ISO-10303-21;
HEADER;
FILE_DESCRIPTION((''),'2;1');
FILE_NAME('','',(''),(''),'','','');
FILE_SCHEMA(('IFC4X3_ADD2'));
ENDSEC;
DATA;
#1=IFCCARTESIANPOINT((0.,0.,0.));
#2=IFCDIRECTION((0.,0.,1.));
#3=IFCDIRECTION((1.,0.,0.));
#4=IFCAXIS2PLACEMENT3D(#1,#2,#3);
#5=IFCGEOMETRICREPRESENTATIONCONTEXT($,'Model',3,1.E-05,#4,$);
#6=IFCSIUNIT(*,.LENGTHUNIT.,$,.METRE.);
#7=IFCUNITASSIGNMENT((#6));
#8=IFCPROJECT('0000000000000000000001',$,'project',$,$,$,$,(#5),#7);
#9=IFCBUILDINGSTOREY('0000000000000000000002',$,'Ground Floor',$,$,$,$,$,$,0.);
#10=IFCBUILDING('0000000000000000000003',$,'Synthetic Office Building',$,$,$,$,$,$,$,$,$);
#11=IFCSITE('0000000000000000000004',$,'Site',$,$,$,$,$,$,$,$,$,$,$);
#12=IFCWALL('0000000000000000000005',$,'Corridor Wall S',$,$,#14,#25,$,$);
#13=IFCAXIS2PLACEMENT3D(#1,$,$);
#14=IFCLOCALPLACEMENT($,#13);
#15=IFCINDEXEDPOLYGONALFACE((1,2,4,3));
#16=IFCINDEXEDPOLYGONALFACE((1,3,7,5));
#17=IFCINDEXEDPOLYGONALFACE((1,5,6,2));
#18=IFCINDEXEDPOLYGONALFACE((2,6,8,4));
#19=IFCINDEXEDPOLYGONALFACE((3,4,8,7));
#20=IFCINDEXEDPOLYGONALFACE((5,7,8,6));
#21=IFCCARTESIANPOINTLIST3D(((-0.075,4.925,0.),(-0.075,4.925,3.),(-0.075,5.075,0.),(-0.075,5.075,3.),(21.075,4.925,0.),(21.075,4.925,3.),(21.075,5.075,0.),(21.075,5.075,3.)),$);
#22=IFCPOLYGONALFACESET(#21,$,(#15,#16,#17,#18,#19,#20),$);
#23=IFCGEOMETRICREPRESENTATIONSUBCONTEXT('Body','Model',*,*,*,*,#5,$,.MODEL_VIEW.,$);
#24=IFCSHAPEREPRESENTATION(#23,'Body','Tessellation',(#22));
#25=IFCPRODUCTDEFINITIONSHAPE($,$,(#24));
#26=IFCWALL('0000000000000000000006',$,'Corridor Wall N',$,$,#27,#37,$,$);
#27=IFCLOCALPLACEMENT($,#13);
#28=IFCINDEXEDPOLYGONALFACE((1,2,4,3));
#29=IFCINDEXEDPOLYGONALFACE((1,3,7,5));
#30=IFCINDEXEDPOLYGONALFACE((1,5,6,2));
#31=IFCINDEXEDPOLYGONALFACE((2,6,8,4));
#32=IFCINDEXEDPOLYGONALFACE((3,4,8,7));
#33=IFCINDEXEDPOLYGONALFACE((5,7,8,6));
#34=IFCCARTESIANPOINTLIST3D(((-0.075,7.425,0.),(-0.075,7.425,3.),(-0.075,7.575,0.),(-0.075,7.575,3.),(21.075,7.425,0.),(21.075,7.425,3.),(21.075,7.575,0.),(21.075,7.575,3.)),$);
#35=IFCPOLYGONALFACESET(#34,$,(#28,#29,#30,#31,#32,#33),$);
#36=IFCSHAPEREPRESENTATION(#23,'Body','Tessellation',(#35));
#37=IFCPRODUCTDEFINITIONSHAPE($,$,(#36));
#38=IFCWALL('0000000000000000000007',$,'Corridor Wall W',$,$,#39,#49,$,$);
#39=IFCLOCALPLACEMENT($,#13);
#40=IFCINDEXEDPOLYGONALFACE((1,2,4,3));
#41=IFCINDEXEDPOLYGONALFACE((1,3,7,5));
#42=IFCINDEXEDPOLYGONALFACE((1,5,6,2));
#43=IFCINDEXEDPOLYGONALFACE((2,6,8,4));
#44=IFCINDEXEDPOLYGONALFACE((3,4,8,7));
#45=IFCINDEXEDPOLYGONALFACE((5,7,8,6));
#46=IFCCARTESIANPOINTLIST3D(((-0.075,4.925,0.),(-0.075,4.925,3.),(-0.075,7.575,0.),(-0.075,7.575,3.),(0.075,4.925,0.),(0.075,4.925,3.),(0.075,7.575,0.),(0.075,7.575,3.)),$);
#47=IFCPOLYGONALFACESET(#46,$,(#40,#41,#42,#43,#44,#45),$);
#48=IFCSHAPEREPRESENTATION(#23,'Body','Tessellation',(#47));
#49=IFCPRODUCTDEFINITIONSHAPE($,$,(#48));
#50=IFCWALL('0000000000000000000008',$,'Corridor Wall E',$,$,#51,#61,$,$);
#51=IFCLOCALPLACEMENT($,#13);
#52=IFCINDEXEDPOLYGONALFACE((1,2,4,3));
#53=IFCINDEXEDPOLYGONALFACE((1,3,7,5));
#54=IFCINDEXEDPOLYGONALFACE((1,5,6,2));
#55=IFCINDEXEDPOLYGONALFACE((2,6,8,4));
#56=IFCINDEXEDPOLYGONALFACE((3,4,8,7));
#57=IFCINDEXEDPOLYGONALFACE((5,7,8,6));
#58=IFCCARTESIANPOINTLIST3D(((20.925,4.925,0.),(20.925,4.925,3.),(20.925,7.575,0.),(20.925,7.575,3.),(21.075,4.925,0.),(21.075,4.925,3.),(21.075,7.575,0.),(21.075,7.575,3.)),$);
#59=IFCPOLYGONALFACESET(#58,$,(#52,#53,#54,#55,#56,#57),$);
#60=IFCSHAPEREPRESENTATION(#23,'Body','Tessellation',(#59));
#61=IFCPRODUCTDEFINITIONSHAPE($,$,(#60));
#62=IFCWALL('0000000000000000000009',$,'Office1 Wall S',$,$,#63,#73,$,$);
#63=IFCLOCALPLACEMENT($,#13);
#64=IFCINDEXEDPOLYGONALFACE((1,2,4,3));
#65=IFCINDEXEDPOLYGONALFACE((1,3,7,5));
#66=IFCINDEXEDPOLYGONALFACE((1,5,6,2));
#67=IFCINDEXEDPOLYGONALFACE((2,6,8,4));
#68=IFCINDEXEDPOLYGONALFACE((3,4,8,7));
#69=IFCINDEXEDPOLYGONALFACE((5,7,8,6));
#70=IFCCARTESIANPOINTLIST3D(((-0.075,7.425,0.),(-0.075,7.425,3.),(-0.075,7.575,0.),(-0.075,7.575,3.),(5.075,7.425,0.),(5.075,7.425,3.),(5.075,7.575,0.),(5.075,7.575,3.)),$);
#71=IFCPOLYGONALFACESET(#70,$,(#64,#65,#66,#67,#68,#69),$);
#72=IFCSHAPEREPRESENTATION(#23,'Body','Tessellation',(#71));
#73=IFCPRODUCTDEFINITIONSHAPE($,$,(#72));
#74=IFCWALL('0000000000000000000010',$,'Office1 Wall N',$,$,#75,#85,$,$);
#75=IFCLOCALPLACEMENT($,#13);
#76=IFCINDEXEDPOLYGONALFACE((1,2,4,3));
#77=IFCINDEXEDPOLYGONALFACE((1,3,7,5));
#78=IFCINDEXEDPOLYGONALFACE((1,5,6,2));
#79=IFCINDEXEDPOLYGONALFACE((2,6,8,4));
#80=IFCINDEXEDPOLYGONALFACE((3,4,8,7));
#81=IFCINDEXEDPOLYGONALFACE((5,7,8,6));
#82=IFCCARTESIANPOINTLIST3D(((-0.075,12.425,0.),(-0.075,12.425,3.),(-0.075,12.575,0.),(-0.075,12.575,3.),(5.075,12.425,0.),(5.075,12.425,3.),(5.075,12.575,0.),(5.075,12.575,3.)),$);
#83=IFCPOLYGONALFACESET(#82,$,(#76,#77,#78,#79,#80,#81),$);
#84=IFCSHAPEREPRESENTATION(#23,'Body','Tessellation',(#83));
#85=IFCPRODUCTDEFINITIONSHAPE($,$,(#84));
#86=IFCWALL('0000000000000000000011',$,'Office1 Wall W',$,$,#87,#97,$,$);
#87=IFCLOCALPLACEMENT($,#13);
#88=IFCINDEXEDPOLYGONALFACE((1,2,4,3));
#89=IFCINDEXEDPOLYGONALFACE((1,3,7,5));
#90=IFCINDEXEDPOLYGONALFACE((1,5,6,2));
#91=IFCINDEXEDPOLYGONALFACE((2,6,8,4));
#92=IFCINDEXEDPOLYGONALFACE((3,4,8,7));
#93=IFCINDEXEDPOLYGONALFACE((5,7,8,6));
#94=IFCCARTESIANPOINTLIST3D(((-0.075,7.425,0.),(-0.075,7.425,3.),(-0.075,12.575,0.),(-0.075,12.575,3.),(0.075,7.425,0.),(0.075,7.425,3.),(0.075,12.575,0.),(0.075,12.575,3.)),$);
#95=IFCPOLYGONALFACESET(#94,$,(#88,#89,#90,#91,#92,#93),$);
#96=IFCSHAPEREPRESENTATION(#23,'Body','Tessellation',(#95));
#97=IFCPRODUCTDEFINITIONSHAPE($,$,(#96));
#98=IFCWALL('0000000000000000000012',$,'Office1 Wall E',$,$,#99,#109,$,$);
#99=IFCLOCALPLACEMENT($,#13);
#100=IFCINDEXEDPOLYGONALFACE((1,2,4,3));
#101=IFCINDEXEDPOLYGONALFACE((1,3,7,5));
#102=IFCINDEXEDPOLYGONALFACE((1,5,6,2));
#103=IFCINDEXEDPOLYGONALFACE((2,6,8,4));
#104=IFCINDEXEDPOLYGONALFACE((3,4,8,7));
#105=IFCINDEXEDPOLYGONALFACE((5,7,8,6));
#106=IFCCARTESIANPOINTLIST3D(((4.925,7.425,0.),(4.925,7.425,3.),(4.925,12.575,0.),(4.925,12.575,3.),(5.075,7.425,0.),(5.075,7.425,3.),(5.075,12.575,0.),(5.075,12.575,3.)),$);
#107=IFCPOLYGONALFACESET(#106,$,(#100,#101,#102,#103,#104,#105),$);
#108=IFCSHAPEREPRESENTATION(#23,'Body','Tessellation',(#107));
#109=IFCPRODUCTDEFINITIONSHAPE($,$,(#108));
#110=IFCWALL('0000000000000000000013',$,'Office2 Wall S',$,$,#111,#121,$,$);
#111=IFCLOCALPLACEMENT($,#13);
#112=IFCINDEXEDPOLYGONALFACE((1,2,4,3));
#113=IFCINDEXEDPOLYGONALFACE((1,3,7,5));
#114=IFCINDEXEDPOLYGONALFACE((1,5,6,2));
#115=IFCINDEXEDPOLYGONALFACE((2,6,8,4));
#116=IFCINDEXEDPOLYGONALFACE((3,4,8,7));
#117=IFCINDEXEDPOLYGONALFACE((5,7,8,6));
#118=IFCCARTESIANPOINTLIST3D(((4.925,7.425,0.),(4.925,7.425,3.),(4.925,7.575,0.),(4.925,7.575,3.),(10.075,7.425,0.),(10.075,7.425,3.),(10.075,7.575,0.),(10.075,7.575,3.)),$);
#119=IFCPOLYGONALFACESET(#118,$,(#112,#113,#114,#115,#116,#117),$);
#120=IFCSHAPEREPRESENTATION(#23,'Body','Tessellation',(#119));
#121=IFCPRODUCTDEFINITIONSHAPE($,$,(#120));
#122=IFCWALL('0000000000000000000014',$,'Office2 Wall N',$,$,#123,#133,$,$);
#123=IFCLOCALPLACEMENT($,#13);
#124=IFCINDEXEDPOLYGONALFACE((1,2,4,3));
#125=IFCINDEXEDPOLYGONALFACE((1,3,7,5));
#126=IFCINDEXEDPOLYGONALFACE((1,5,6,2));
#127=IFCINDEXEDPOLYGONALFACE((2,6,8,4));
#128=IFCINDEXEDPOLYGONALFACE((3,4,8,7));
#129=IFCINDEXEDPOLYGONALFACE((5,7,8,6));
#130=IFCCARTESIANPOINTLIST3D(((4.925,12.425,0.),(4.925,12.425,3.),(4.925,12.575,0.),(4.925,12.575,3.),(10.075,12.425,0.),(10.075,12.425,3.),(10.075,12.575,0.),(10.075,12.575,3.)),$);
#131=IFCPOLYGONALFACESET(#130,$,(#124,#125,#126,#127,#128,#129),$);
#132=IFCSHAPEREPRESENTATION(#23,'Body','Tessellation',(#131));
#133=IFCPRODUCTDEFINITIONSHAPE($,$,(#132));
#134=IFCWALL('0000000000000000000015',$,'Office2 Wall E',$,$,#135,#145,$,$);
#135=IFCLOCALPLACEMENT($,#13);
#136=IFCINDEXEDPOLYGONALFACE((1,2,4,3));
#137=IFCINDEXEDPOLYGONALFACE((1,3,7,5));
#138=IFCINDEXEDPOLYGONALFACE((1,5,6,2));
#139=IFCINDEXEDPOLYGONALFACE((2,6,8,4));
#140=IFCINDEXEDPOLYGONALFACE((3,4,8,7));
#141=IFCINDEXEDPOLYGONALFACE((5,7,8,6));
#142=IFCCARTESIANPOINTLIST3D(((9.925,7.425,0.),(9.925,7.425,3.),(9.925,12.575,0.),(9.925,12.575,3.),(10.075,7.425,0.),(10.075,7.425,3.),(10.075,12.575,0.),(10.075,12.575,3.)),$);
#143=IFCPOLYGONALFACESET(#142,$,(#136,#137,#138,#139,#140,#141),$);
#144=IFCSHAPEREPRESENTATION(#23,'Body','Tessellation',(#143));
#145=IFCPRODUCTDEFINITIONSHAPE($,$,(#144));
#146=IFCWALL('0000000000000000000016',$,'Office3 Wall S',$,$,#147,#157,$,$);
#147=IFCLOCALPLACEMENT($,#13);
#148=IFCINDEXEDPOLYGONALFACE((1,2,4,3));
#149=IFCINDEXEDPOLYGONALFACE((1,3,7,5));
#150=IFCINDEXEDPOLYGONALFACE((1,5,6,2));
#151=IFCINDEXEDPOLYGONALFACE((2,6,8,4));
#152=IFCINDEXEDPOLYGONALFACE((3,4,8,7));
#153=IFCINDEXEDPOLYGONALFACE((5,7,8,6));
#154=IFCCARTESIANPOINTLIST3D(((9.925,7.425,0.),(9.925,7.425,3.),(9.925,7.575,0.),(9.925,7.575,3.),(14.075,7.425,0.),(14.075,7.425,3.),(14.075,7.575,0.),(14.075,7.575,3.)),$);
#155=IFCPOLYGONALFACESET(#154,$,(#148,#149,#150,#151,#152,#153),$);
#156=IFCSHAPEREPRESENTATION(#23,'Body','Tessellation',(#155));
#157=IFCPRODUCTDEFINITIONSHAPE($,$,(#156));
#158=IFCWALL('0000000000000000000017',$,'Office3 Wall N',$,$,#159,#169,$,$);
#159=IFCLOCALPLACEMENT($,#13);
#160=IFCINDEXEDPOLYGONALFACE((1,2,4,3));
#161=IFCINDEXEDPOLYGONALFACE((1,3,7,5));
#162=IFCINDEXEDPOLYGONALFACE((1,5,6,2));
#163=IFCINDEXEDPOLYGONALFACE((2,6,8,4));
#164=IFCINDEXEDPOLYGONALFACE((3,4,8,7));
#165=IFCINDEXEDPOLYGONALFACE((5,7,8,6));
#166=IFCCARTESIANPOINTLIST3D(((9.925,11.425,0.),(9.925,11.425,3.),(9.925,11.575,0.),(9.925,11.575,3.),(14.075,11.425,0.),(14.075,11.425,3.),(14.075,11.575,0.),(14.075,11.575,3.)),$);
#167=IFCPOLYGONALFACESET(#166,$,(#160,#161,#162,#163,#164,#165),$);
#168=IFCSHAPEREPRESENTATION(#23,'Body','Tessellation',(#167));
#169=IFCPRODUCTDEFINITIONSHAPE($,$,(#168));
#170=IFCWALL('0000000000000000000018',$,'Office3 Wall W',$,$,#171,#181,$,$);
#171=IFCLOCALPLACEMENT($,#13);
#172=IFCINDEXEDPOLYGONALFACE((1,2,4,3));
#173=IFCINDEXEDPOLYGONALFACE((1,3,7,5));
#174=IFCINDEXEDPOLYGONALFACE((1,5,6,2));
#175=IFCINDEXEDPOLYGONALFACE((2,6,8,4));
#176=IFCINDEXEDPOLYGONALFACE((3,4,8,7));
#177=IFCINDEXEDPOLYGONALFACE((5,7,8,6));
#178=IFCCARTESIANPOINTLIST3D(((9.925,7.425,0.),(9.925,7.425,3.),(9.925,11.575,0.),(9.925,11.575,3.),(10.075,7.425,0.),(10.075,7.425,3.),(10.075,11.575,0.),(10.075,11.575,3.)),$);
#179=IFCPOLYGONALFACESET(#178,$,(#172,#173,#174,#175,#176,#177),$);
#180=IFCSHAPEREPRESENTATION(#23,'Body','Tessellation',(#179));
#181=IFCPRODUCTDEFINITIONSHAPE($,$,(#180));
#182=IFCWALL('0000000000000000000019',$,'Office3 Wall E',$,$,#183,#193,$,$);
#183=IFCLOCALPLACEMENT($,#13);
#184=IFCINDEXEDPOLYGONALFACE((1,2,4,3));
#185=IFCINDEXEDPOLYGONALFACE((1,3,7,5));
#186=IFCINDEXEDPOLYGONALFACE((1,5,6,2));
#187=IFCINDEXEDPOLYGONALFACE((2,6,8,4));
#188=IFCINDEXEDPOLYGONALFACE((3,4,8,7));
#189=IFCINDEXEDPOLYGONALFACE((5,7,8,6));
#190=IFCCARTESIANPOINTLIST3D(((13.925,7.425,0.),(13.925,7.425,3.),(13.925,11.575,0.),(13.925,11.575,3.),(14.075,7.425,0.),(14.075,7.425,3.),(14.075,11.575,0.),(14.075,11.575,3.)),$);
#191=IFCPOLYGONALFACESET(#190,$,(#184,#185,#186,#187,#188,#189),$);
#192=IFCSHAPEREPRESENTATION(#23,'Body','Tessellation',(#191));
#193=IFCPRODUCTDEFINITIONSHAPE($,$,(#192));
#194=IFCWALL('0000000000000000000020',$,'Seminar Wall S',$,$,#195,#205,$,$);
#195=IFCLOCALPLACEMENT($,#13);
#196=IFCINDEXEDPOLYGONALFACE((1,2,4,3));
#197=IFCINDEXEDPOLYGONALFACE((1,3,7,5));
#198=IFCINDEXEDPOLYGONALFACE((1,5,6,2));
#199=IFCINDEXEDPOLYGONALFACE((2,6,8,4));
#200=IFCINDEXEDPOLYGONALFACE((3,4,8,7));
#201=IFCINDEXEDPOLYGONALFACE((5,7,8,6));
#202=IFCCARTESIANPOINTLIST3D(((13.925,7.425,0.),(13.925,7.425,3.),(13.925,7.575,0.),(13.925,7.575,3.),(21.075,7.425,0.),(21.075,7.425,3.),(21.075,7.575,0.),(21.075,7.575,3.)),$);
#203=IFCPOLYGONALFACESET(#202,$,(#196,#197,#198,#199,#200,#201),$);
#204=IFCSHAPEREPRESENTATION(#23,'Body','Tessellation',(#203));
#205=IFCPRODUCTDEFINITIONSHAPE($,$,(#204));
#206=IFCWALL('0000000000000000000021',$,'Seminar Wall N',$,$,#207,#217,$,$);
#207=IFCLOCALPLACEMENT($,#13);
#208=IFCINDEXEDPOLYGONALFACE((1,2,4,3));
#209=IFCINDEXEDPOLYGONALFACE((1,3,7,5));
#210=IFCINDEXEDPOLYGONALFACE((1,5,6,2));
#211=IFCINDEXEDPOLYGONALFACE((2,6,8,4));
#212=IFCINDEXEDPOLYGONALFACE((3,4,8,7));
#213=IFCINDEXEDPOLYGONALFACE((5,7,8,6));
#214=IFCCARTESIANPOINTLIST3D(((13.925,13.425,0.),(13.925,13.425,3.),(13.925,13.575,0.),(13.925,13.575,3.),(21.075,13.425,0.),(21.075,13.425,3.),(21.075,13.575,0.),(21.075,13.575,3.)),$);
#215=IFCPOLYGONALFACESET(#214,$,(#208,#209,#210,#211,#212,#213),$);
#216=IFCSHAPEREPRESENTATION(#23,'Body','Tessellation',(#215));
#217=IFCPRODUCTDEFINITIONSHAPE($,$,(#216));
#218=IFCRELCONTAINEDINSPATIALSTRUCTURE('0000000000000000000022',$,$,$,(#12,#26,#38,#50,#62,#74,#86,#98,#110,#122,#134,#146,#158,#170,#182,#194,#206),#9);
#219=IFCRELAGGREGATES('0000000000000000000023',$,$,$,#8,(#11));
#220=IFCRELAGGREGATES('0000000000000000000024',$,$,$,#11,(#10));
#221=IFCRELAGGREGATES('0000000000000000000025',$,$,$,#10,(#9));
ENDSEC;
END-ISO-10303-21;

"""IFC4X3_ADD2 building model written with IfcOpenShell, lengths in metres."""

from ifc_helpers import new_model, si_unit, origin_with_axes, place, context, subcontext, project, spatial, polyline, outline, extrude, element, save


model = new_model("IFC4X3_ADD2")

# Units and contexts
model_context = context("Model", 3, precision=1e-05, world=origin_with_axes())
body_context = subcontext(model_context, "Body", "Model", "MODEL_VIEW")
ifc_project = project(units=[si_unit("LENGTHUNIT", "METRE")], contexts=[model_context])

# Site, building, storey
site = spatial("IfcSite", under=ifc_project, Name="Site")
building = spatial("IfcBuilding", under=site, Name="Synthetic Office Building")
storey = spatial("IfcBuildingStorey", under=building, Name="Ground Floor", Elevation=0.0)

# Walls
wall_1_placement = place(None, origin_with_axes())
element("IfcWall", 1, at=wall_1_placement, inside=storey, Name="Corridor Wall S", context=body_context, shape_type="SweptSolid", body=[
    extrude(outline(polyline([(-0.075, 4.925), (21.075, 4.925), (21.075, 5.075), (-0.075, 5.075), (-0.075, 4.925)])), origin_with_axes(), (0.0, 0.0, 1.0), 3.0),
])
wall_2_placement = place(None, origin_with_axes())
element("IfcWall", 2, at=wall_2_placement, inside=storey, Name="Corridor Wall N", context=body_context, shape_type="SweptSolid", body=[
    extrude(outline(polyline([(-0.075, 7.425), (21.075, 7.425), (21.075, 7.575), (-0.075, 7.575), (-0.075, 7.425)])), origin_with_axes(), (0.0, 0.0, 1.0), 3.0),
])
wall_3_placement = place(None, origin_with_axes())
element("IfcWall", 3, at=wall_3_placement, inside=storey, Name="Corridor Wall W", context=body_context, shape_type="SweptSolid", body=[
    extrude(outline(polyline([(-0.075, 4.925), (0.075, 4.925), (0.075, 7.575), (-0.075, 7.575), (-0.075, 4.925)])), origin_with_axes(), (0.0, 0.0, 1.0), 3.0),
])
wall_4_placement = place(None, origin_with_axes())
element("IfcWall", 4, at=wall_4_placement, inside=storey, Name="Corridor Wall E", context=body_context, shape_type="SweptSolid", body=[
    extrude(outline(polyline([(20.925, 4.925), (21.075, 4.925), (21.075, 7.575), (20.925, 7.575), (20.925, 4.925)])), origin_with_axes(), (0.0, 0.0, 1.0), 3.0),
])
wall_5_placement = place(None, origin_with_axes())
element("IfcWall", 5, at=wall_5_placement, inside=storey, Name="Office1 Wall S", context=body_context, shape_type="SweptSolid", body=[
    extrude(outline(polyline([(-0.075, 7.425), (5.075, 7.425), (5.075, 7.575), (-0.075, 7.575), (-0.075, 7.425)])), origin_with_axes(), (0.0, 0.0, 1.0), 3.0),
])
wall_6_placement = place(None, origin_with_axes())
element("IfcWall", 6, at=wall_6_placement, inside=storey, Name="Office1 Wall N", context=body_context, shape_type="SweptSolid", body=[
    extrude(outline(polyline([(-0.075, 12.425), (5.075, 12.425), (5.075, 12.575), (-0.075, 12.575), (-0.075, 12.425)])), origin_with_axes(), (0.0, 0.0, 1.0), 3.0),
])
wall_7_placement = place(None, origin_with_axes())
element("IfcWall", 7, at=wall_7_placement, inside=storey, Name="Office1 Wall W", context=body_context, shape_type="SweptSolid", body=[
    extrude(outline(polyline([(-0.075, 7.425), (0.075, 7.425), (0.075, 12.575), (-0.075, 12.575), (-0.075, 7.425)])), origin_with_axes(), (0.0, 0.0, 1.0), 3.0),
])
wall_8_placement = place(None, origin_with_axes())
element("IfcWall", 8, at=wall_8_placement, inside=storey, Name="Office1 Wall E", context=body_context, shape_type="SweptSolid", body=[
    extrude(outline(polyline([(4.925, 7.425), (5.075, 7.425), (5.075, 12.575), (4.925, 12.575), (4.925, 7.425)])), origin_with_axes(), (0.0, 0.0, 1.0), 3.0),
])
wall_9_placement = place(None, origin_with_axes())
element("IfcWall", 9, at=wall_9_placement, inside=storey, Name="Office2 Wall S", context=body_context, shape_type="SweptSolid", body=[
    extrude(outline(polyline([(4.925, 7.425), (10.075, 7.425), (10.075, 7.575), (4.925, 7.575), (4.925, 7.425)])), origin_with_axes(), (0.0, 0.0, 1.0), 3.0),
])
wall_10_placement = place(None, origin_with_axes())
element("IfcWall", 10, at=wall_10_placement, inside=storey, Name="Office2 Wall N", context=body_context, shape_type="SweptSolid", body=[
    extrude(outline(polyline([(4.925, 12.425), (10.075, 12.425), (10.075, 12.575), (4.925, 12.575), (4.925, 12.425)])), origin_with_axes(), (0.0, 0.0, 1.0), 3.0),
])
wall_11_placement = place(None, origin_with_axes())
element("IfcWall", 11, at=wall_11_placement, inside=storey, Name="Office2 Wall E", context=body_context, shape_type="SweptSolid", body=[
    extrude(outline(polyline([(9.925, 7.425), (10.075, 7.425), (10.075, 12.575), (9.925, 12.575), (9.925, 7.425)])), origin_with_axes(), (0.0, 0.0, 1.0), 3.0),
])
wall_12_placement = place(None, origin_with_axes())
element("IfcWall", 12, at=wall_12_placement, inside=storey, Name="Office3 Wall S", context=body_context, shape_type="SweptSolid", body=[
    extrude(outline(polyline([(9.925, 7.425), (14.075, 7.425), (14.075, 7.575), (9.925, 7.575), (9.925, 7.425)])), origin_with_axes(), (0.0, 0.0, 1.0), 3.0),
])
wall_13_placement = place(None, origin_with_axes())
element("IfcWall", 13, at=wall_13_placement, inside=storey, Name="Office3 Wall N", context=body_context, shape_type="SweptSolid", body=[
    extrude(outline(polyline([(9.925, 11.425), (14.075, 11.425), (14.075, 11.575), (9.925, 11.575), (9.925, 11.425)])), origin_with_axes(), (0.0, 0.0, 1.0), 3.0),
])
wall_14_placement = place(None, origin_with_axes())
element("IfcWall", 14, at=wall_14_placement, inside=storey, Name="Office3 Wall W", context=body_context, shape_type="SweptSolid", body=[
    extrude(outline(polyline([(9.925, 7.425), (10.075, 7.425), (10.075, 11.575), (9.925, 11.575), (9.925, 7.425)])), origin_with_axes(), (0.0, 0.0, 1.0), 3.0),
])
wall_15_placement = place(None, origin_with_axes())
element("IfcWall", 15, at=wall_15_placement, inside=storey, Name="Office3 Wall E", context=body_context, shape_type="SweptSolid", body=[
    extrude(outline(polyline([(13.925, 7.425), (14.075, 7.425), (14.075, 11.575), (13.925, 11.575), (13.925, 7.425)])), origin_with_axes(), (0.0, 0.0, 1.0), 3.0),
])
wall_16_placement = place(None, origin_with_axes())
element("IfcWall", 16, at=wall_16_placement, inside=storey, Name="Seminar Wall S", context=body_context, shape_type="SweptSolid", body=[
    extrude(outline(polyline([(13.925, 7.425), (21.075, 7.425), (21.075, 7.575), (13.925, 7.575), (13.925, 7.425)])), origin_with_axes(), (0.0, 0.0, 1.0), 3.0),
])
wall_17_placement = place(None, origin_with_axes())
element("IfcWall", 17, at=wall_17_placement, inside=storey, Name="Seminar Wall N", context=body_context, shape_type="SweptSolid", body=[
    extrude(outline(polyline([(13.925, 13.425), (21.075, 13.425), (21.075, 13.575), (13.925, 13.575), (13.925, 13.425)])), origin_with_axes(), (0.0, 0.0, 1.0), 3.0),
])

save(model, "model.ifc")
